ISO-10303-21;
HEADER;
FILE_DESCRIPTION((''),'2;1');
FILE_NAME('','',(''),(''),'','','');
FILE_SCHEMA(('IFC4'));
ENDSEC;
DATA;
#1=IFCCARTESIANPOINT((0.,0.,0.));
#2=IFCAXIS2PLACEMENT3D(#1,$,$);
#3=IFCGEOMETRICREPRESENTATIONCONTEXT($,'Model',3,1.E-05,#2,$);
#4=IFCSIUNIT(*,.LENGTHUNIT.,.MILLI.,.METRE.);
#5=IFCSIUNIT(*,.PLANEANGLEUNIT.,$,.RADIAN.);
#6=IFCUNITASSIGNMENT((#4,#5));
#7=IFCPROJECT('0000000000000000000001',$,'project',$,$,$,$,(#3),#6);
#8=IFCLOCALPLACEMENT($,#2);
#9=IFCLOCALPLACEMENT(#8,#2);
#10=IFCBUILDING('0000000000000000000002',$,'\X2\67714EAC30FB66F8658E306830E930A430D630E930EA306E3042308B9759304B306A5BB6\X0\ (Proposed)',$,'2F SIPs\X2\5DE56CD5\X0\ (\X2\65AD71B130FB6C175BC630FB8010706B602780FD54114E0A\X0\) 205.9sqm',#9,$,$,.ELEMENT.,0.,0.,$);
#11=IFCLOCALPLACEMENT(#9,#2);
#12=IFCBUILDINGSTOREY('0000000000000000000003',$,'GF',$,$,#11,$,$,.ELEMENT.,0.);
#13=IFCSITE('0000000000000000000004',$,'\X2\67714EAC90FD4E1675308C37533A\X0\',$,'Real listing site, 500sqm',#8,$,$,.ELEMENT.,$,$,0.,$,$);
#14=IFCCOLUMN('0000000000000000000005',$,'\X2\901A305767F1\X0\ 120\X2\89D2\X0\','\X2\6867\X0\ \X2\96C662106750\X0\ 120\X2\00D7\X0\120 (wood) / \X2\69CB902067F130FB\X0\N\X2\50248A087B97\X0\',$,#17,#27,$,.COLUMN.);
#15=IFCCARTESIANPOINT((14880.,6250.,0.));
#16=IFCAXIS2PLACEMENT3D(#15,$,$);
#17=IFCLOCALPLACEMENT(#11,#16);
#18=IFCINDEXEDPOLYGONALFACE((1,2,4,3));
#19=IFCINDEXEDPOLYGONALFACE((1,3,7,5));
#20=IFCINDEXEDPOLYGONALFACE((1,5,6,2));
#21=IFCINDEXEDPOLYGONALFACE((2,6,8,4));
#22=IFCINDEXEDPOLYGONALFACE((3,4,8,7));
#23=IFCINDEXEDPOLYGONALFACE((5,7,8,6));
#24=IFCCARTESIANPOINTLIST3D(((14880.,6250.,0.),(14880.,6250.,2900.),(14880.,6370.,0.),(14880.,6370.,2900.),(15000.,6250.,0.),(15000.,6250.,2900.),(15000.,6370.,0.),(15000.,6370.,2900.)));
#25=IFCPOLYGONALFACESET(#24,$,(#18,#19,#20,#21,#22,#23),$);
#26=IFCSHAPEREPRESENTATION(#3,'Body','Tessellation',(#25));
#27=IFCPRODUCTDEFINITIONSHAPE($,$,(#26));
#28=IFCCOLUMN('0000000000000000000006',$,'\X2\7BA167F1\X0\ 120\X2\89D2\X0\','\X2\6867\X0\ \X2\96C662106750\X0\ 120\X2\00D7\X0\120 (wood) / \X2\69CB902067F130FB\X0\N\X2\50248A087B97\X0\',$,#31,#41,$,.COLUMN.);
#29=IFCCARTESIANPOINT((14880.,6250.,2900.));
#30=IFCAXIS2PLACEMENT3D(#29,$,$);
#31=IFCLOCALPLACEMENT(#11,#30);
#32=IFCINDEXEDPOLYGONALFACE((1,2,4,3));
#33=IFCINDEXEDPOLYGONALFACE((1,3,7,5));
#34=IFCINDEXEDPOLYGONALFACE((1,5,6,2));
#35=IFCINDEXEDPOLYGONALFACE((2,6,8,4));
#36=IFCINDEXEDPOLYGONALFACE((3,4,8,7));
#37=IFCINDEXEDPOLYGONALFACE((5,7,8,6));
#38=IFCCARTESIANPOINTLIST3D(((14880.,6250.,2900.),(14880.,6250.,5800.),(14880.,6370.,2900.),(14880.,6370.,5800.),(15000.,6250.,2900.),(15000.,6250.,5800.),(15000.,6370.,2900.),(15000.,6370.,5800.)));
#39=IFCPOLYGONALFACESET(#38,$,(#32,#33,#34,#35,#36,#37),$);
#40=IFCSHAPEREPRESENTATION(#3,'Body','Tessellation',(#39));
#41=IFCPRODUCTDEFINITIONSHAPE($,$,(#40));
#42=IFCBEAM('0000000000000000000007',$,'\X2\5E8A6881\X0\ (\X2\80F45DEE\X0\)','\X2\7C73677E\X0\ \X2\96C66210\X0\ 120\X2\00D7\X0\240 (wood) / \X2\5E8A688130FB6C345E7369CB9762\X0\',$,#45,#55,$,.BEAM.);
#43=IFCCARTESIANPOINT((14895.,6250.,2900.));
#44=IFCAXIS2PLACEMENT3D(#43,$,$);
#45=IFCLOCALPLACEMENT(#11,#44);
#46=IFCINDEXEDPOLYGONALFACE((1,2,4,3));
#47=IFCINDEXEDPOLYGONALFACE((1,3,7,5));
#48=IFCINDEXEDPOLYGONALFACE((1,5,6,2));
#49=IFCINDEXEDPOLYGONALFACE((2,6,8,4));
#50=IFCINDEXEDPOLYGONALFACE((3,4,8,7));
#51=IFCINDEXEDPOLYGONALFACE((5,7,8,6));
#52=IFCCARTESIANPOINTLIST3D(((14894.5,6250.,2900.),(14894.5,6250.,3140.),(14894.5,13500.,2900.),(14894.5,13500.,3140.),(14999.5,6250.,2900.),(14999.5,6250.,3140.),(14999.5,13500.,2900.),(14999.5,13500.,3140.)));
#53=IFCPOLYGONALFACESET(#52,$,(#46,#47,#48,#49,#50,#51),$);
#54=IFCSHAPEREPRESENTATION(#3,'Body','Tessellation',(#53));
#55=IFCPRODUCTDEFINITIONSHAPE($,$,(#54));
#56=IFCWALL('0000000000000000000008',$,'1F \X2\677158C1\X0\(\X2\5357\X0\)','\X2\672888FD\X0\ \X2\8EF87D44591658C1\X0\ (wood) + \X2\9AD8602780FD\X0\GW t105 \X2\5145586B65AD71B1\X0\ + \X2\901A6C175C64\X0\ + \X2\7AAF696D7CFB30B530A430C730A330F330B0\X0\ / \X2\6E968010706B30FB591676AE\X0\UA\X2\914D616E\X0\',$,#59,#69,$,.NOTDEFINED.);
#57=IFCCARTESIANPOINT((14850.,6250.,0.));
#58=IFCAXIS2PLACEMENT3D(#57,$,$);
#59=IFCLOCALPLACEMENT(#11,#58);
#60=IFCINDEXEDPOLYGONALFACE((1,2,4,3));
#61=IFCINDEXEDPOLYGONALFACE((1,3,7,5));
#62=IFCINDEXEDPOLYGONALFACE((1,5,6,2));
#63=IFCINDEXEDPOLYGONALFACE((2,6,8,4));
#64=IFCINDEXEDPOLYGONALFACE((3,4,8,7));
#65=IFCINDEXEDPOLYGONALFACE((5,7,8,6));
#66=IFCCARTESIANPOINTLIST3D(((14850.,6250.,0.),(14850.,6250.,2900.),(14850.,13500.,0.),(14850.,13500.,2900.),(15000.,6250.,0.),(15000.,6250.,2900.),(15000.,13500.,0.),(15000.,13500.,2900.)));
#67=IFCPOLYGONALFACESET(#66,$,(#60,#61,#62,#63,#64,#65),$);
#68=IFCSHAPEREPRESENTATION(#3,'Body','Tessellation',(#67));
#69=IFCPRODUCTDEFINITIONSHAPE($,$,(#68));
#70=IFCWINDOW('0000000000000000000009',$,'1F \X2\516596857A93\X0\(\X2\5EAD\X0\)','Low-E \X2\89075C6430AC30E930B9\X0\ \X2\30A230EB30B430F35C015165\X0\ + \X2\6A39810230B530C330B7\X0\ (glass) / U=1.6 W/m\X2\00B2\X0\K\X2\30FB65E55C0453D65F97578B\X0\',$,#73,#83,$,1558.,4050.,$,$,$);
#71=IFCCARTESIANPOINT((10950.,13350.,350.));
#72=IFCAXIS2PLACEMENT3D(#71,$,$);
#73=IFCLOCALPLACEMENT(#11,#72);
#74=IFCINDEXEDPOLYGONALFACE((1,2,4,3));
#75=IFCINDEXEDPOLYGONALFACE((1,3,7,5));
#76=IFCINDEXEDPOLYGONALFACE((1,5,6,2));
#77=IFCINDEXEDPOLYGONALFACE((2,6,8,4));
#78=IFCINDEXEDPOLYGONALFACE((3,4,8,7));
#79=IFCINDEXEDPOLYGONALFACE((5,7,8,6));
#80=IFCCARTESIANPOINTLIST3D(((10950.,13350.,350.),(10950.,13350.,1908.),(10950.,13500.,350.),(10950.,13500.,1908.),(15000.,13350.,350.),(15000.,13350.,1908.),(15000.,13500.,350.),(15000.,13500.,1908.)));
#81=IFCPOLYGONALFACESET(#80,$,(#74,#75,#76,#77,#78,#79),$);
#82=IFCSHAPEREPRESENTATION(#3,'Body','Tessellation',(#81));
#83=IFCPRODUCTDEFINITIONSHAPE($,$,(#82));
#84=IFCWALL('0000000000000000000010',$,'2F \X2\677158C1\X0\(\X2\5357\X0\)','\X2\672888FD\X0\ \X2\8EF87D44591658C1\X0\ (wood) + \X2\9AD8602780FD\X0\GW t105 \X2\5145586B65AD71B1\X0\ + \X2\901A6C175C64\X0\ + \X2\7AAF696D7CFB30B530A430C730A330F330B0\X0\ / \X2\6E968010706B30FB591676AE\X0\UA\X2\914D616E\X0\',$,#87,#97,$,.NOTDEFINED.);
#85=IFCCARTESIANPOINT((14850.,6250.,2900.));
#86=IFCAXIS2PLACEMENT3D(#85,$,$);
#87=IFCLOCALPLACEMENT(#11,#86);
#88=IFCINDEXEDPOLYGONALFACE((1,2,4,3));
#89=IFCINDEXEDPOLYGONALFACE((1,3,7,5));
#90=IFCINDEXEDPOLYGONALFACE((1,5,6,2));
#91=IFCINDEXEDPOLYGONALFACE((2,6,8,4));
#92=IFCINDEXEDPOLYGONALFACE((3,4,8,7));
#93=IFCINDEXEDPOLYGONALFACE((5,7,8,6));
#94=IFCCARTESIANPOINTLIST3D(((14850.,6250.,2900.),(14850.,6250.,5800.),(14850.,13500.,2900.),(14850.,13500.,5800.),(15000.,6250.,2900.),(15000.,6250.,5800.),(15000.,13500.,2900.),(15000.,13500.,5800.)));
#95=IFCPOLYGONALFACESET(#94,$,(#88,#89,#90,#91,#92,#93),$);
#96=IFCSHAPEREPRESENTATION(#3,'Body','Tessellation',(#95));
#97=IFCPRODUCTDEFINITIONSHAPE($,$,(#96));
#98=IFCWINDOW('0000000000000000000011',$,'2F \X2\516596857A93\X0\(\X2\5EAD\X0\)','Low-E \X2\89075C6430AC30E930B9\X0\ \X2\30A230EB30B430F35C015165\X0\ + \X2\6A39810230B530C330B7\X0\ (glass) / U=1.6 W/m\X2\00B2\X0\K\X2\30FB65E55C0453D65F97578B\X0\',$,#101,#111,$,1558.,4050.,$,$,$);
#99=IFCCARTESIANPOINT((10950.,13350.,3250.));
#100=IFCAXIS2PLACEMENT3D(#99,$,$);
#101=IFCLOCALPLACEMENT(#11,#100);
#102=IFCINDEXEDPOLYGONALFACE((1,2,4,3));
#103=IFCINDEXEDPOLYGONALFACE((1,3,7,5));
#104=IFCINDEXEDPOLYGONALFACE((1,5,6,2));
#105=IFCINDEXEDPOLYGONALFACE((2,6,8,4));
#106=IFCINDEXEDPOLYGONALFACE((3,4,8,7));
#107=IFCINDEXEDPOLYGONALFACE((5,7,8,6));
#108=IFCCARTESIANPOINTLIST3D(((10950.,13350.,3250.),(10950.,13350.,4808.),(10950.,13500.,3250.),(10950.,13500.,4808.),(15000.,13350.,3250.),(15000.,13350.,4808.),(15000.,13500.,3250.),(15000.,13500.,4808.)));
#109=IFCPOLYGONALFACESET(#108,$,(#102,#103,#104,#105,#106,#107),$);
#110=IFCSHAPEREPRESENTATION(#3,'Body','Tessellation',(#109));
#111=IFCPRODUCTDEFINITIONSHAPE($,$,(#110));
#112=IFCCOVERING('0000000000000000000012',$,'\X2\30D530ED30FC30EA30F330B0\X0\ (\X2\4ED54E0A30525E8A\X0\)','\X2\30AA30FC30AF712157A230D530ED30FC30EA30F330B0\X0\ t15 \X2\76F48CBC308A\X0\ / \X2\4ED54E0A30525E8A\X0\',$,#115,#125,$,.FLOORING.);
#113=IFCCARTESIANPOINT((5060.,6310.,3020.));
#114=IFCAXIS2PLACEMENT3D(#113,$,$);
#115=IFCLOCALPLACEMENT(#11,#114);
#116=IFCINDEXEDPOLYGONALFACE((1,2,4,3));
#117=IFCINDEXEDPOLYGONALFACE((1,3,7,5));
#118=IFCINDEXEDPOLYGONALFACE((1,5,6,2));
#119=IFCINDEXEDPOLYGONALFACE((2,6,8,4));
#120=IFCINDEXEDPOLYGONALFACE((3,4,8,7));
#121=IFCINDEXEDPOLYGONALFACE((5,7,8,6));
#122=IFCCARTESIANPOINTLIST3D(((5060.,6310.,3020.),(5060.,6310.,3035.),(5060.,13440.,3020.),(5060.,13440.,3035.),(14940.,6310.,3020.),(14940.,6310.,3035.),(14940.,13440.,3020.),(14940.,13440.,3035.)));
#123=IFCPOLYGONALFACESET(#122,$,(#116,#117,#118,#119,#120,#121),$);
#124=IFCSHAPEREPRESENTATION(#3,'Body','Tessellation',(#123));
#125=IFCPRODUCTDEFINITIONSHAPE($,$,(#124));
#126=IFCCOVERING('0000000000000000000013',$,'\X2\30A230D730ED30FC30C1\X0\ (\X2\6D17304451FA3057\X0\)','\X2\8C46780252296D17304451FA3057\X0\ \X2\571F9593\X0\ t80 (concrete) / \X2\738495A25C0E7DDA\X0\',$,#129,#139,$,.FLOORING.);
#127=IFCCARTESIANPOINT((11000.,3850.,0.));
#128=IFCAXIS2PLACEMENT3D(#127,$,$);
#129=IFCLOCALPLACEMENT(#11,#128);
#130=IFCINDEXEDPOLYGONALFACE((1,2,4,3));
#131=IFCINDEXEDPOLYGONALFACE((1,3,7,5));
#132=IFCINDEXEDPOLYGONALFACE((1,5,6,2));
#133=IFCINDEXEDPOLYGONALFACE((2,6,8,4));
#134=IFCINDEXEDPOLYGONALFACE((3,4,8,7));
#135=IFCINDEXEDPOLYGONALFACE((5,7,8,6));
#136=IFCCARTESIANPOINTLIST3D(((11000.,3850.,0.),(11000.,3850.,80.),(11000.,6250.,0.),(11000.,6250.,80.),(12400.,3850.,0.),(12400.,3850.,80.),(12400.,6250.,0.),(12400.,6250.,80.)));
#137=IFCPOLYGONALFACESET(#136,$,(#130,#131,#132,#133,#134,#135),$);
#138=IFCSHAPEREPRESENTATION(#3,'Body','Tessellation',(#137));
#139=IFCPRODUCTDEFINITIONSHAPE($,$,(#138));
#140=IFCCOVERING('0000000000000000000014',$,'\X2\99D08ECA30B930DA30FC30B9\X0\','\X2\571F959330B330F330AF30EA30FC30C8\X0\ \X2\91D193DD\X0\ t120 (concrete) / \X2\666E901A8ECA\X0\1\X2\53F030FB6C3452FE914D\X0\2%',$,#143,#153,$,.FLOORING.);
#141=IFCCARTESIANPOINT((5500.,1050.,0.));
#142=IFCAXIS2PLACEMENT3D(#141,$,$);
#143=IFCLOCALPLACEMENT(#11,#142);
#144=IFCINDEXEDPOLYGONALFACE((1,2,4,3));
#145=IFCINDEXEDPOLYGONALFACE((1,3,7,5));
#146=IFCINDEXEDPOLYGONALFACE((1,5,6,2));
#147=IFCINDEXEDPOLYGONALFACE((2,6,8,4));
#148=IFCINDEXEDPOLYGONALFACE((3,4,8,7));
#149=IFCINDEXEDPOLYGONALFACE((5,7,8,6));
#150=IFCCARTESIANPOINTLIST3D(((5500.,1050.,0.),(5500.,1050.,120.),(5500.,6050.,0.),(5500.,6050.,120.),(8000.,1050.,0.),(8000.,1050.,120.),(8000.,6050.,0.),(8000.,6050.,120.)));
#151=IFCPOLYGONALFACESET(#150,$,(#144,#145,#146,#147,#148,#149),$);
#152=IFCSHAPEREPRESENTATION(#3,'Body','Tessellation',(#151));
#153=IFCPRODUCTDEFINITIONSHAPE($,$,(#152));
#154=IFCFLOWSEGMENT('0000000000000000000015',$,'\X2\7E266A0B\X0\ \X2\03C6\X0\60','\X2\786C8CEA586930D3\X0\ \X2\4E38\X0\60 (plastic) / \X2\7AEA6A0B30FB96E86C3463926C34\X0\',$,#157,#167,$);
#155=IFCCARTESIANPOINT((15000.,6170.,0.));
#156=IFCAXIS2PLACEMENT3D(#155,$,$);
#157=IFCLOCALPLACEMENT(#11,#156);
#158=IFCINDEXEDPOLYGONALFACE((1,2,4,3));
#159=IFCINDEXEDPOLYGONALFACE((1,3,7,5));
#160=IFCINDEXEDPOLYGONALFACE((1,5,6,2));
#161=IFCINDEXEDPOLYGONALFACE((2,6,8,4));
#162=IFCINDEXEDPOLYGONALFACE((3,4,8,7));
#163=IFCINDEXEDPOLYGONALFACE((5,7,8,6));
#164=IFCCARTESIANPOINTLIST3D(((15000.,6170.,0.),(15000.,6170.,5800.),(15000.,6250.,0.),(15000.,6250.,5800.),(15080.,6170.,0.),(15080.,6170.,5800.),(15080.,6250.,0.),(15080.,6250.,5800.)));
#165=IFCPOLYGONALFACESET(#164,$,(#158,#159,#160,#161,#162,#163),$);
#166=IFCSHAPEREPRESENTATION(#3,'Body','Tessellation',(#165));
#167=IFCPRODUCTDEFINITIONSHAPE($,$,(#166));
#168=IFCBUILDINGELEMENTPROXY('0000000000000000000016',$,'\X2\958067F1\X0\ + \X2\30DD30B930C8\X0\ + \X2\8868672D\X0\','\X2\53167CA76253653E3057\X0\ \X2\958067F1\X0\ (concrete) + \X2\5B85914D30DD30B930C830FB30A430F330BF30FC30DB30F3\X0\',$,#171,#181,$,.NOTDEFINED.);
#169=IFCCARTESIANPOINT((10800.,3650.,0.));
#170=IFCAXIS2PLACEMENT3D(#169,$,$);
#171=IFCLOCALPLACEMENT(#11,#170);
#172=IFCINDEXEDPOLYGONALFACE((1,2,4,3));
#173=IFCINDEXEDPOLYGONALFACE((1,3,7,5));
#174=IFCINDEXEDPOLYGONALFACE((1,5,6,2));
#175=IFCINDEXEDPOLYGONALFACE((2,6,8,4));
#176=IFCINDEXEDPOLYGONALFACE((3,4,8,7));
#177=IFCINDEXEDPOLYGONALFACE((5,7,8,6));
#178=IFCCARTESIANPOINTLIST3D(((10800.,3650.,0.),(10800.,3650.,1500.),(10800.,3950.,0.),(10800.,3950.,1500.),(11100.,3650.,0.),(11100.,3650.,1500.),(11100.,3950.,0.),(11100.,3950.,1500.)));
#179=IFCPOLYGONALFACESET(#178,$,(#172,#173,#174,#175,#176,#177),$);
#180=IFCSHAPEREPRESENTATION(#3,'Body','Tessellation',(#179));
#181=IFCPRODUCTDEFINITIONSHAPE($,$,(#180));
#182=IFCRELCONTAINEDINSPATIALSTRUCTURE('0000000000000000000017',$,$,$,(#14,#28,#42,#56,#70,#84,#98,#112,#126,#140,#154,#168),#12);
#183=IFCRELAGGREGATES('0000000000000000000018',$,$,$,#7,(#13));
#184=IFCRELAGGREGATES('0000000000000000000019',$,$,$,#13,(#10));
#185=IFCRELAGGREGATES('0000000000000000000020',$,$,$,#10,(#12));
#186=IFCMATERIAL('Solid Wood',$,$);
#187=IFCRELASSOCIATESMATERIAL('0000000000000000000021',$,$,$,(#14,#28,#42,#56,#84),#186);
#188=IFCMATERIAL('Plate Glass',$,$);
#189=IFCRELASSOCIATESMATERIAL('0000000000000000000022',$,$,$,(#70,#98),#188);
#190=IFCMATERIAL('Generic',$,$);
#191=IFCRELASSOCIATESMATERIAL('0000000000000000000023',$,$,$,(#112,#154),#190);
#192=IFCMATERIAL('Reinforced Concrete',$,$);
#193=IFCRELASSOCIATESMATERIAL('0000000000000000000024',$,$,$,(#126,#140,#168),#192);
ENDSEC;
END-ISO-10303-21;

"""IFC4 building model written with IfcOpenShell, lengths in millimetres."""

from ifc_helpers import new_model, si_unit, frame, frame_2d, origin, place, context, project, spatial, rectangle, extrude, material, element, fill, save


model = new_model("IFC4")

# Units and contexts
model_context = context("Model", 3, precision=1e-05, world=origin())
ifc_project = project(units=[si_unit("LENGTHUNIT", "METRE", prefix="MILLI"), si_unit("PLANEANGLEUNIT", "RADIAN")], contexts=[model_context])

# Site, building, storey
site_placement = place(None, origin())
site = spatial("IfcSite", under=ifc_project, at=site_placement, Name="東京都世田谷区", ObjectType="Real listing site, 500sqm", CompositionType="ELEMENT", RefElevation=0.0)
building_placement = place(site_placement, origin())
building = spatial("IfcBuilding", under=site, at=building_placement, Name="東京・書斎とライブラリのある静かな家 (Proposed)", ObjectType="2F SIPs工法 (断熱・気密・耐火性能向上) 205.9sqm", CompositionType="ELEMENT", ElevationOfRefHeight=0.0, ElevationOfTerrain=0.0)
storey_placement = place(building_placement, origin())
storey = spatial("IfcBuildingStorey", under=building, at=storey_placement, Name="GF", CompositionType="ELEMENT", Elevation=0.0)

# Columns
ifc_material_1 = material(Name="Solid Wood")
column_1_placement = place(storey_placement, frame((14880.0, 6250.0, 0.0)))
element("IfcColumn", 1, at=column_1_placement, inside=storey, material=ifc_material_1, Name="通し柱 120角", Description="桧 集成材 120×120 (wood) / 構造柱・N値計算", PredefinedType="COLUMN", context=model_context, shape_type="SweptSolid", body=[
    extrude(rectangle(XDim=120.0, YDim=120.0, at=frame_2d((60.0, 60.0))), frame((14880.0, 6250.0, 0.0)), (0.0, 0.0, 1.0), 2900.0),
])
column_2_placement = place(storey_placement, frame((14880.0, 6250.0, 2900.0)))
element("IfcColumn", 2, at=column_2_placement, inside=storey, material=ifc_material_1, Name="管柱 120角", Description="桧 集成材 120×120 (wood) / 構造柱・N値計算", PredefinedType="COLUMN", context=model_context, shape_type="SweptSolid", body=[
    extrude(rectangle(XDim=120.0, YDim=120.0, at=frame_2d((60.0, 60.0))), frame((14880.0, 6250.0, 2900.0)), (0.0, 0.0, 1.0), 2900.0),
])

# Beam
beam_1_placement = place(storey_placement, frame((14895.0, 6250.0, 2900.0)))
element("IfcBeam", 3, at=beam_1_placement, inside=storey, material=ifc_material_1, Name="床梁 (胴差)", Description="米松 集成 120×240 (wood) / 床梁・水平構面", PredefinedType="BEAM", context=model_context, shape_type="SweptSolid", body=[
    extrude(rectangle(XDim=105.0, YDim=7250.0, at=frame_2d((52.0, 3625.0))), frame((14895.0, 6250.0, 2900.0)), (0.0, 0.0, 1.0), 240.0),
])

# Wall, opening, window
wall_1_placement = place(storey_placement, frame((14850.0, 6250.0, 0.0)))
wall_1 = element("IfcWall", 4, at=wall_1_placement, inside=storey, material=ifc_material_1, Name="1F 東壁(南)", Description="木製 軸組外壁 (wood) + 高性能GW t105 充填断熱 + 通気層 + 窯業系サイディング / 準耐火・外皮UA配慮", PredefinedType="NOTDEFINED", context=model_context, shape_type="SweptSolid", body=[
    extrude(rectangle(XDim=150.0, YDim=7250.0, at=frame_2d((75.0, 3625.0))), frame((14850.0, 6250.0, 0.0)), (0.0, 0.0, 1.0), 2900.0),
])
opening_1_placement = place(storey_placement, frame((10950.0, 13350.0, 350.0)))
opening_1 = element("IfcOpeningElement", 5, at=opening_1_placement, cuts=wall_1, PredefinedType="NOTDEFINED", context=model_context, shape_type="SweptSolid", body=[
    extrude(rectangle(XDim=4050.0, YDim=150.0, at=frame_2d((2025.0, 75.0))), frame((10950.0, 13350.0, 350.0)), (0.0, 0.0, 1.0), 1558.0),
])
ifc_material_2 = material(Name="Plate Glass")
window_1_placement = place(storey_placement, frame((10950.0, 13350.0, 350.0)))
window_1 = element("IfcWindow", 6, at=window_1_placement, inside=storey, material=ifc_material_2, Name="1F 入隅窓(庭)", Description="Low-E 複層ガラス アルゴン封入 + 樹脂サッシ (glass) / U=1.6 W/m²K・日射取得型", OverallHeight=1558.0, OverallWidth=4050.0, context=model_context, shape_type="SweptSolid", body=[
    extrude(rectangle(XDim=4050.0, YDim=150.0, at=frame_2d((2025.0, 75.0))), frame((10950.0, 13350.0, 350.0)), (0.0, 0.0, 1.0), 1558.0),
])
fill(opening_1, window_1)

# Wall, opening, window
wall_2_placement = place(storey_placement, frame((14850.0, 6250.0, 2900.0)))
wall_2 = element("IfcWall", 7, at=wall_2_placement, inside=storey, material=ifc_material_1, Name="2F 東壁(南)", Description="木製 軸組外壁 (wood) + 高性能GW t105 充填断熱 + 通気層 + 窯業系サイディング / 準耐火・外皮UA配慮", PredefinedType="NOTDEFINED", context=model_context, shape_type="SweptSolid", body=[
    extrude(rectangle(XDim=150.0, YDim=7250.0, at=frame_2d((75.0, 3625.0))), frame((14850.0, 6250.0, 2900.0)), (0.0, 0.0, 1.0), 2900.0),
])
opening_2_placement = place(storey_placement, frame((10950.0, 13350.0, 3250.0)))
opening_2 = element("IfcOpeningElement", 8, at=opening_2_placement, cuts=wall_2, PredefinedType="NOTDEFINED", context=model_context, shape_type="SweptSolid", body=[
    extrude(rectangle(XDim=4050.0, YDim=150.0, at=frame_2d((2025.0, 75.0))), frame((10950.0, 13350.0, 3250.0)), (0.0, 0.0, 1.0), 1558.0),
])
window_2_placement = place(storey_placement, frame((10950.0, 13350.0, 3250.0)))
window_2 = element("IfcWindow", 9, at=window_2_placement, inside=storey, material=ifc_material_2, Name="2F 入隅窓(庭)", Description="Low-E 複層ガラス アルゴン封入 + 樹脂サッシ (glass) / U=1.6 W/m²K・日射取得型", OverallHeight=1558.0, OverallWidth=4050.0, context=model_context, shape_type="SweptSolid", body=[
    extrude(rectangle(XDim=4050.0, YDim=150.0, at=frame_2d((2025.0, 75.0))), frame((10950.0, 13350.0, 3250.0)), (0.0, 0.0, 1.0), 1558.0),
])
fill(opening_2, window_2)

# Coverings
ifc_material_3 = material(Name="Generic")
covering_1_placement = place(storey_placement, frame((5060.0, 6310.0, 3020.0)))
element("IfcCovering", 10, at=covering_1_placement, inside=storey, material=ifc_material_3, Name="フローリング (仕上げ床)", Description="オーク無垢フローリング t15 直貼り / 仕上げ床", PredefinedType="FLOORING", context=model_context, shape_type="SweptSolid", body=[
    extrude(rectangle(XDim=9880.0, YDim=7130.0, at=frame_2d((4940.0, 3565.0))), frame((5060.0, 6310.0, 3020.0)), (0.0, 0.0, 1.0), 15.0),
])
ifc_material_4 = material(Name="Reinforced Concrete")
covering_2_placement = place(storey_placement, frame((11000.0, 3850.0, 0.0)))
element("IfcCovering", 11, at=covering_2_placement, inside=storey, material=ifc_material_4, Name="アプローチ (洗い出し)", Description="豆砂利洗い出し 土間 t80 (concrete) / 玄関導線", PredefinedType="FLOORING", context=model_context, shape_type="SweptSolid", body=[
    extrude(rectangle(XDim=1400.0, YDim=2400.0, at=frame_2d((700.0, 1200.0))), frame((11000.0, 3850.0, 0.0)), (0.0, 0.0, 1.0), 80.0),
])
covering_3_placement = place(storey_placement, frame((5500.0, 1050.0, 0.0)))
element("IfcCovering", 12, at=covering_3_placement, inside=storey, material=ifc_material_4, Name="駐車スペース", Description="土間コンクリート 金鏝 t120 (concrete) / 普通車1台・水勾配2%", PredefinedType="FLOORING", context=model_context, shape_type="SweptSolid", body=[
    extrude(rectangle(XDim=2500.0, YDim=5000.0, at=frame_2d((1250.0, 2500.0))), frame((5500.0, 1050.0, 0.0)), (0.0, 0.0, 1.0), 120.0),
])

# Flow segment
flow_segment_placement = place(storey_placement, frame((15000.0, 6170.0, 0.0)))
element("IfcFlowSegment", 13, at=flow_segment_placement, inside=storey, material=ifc_material_3, Name="縦樋 φ60", Description="硬質塩ビ 丸60 (plastic) / 竪樋・雨水排水", context=model_context, shape_type="SweptSolid", body=[
    extrude(rectangle(XDim=80.0, YDim=80.0, at=frame_2d((40.0, 40.0))), frame((15000.0, 6170.0, 0.0)), (0.0, 0.0, 1.0), 5800.0),
])

# Building element proxy
proxy_placement = place(storey_placement, frame((10800.0, 3650.0, 0.0)))
element("IfcBuildingElementProxy", 14, at=proxy_placement, inside=storey, material=ifc_material_4, Name="門柱 + ポスト + 表札", Description="化粧打放し 門柱 (concrete) + 宅配ポスト・インターホン", PredefinedType="NOTDEFINED", context=model_context, shape_type="SweptSolid", body=[
    extrude(rectangle(XDim=300.0, YDim=300.0, at=frame_2d((150.0, 150.0))), frame((10800.0, 3650.0, 0.0)), (0.0, 0.0, 1.0), 1500.0),
])

save(model, "model.ifc")
